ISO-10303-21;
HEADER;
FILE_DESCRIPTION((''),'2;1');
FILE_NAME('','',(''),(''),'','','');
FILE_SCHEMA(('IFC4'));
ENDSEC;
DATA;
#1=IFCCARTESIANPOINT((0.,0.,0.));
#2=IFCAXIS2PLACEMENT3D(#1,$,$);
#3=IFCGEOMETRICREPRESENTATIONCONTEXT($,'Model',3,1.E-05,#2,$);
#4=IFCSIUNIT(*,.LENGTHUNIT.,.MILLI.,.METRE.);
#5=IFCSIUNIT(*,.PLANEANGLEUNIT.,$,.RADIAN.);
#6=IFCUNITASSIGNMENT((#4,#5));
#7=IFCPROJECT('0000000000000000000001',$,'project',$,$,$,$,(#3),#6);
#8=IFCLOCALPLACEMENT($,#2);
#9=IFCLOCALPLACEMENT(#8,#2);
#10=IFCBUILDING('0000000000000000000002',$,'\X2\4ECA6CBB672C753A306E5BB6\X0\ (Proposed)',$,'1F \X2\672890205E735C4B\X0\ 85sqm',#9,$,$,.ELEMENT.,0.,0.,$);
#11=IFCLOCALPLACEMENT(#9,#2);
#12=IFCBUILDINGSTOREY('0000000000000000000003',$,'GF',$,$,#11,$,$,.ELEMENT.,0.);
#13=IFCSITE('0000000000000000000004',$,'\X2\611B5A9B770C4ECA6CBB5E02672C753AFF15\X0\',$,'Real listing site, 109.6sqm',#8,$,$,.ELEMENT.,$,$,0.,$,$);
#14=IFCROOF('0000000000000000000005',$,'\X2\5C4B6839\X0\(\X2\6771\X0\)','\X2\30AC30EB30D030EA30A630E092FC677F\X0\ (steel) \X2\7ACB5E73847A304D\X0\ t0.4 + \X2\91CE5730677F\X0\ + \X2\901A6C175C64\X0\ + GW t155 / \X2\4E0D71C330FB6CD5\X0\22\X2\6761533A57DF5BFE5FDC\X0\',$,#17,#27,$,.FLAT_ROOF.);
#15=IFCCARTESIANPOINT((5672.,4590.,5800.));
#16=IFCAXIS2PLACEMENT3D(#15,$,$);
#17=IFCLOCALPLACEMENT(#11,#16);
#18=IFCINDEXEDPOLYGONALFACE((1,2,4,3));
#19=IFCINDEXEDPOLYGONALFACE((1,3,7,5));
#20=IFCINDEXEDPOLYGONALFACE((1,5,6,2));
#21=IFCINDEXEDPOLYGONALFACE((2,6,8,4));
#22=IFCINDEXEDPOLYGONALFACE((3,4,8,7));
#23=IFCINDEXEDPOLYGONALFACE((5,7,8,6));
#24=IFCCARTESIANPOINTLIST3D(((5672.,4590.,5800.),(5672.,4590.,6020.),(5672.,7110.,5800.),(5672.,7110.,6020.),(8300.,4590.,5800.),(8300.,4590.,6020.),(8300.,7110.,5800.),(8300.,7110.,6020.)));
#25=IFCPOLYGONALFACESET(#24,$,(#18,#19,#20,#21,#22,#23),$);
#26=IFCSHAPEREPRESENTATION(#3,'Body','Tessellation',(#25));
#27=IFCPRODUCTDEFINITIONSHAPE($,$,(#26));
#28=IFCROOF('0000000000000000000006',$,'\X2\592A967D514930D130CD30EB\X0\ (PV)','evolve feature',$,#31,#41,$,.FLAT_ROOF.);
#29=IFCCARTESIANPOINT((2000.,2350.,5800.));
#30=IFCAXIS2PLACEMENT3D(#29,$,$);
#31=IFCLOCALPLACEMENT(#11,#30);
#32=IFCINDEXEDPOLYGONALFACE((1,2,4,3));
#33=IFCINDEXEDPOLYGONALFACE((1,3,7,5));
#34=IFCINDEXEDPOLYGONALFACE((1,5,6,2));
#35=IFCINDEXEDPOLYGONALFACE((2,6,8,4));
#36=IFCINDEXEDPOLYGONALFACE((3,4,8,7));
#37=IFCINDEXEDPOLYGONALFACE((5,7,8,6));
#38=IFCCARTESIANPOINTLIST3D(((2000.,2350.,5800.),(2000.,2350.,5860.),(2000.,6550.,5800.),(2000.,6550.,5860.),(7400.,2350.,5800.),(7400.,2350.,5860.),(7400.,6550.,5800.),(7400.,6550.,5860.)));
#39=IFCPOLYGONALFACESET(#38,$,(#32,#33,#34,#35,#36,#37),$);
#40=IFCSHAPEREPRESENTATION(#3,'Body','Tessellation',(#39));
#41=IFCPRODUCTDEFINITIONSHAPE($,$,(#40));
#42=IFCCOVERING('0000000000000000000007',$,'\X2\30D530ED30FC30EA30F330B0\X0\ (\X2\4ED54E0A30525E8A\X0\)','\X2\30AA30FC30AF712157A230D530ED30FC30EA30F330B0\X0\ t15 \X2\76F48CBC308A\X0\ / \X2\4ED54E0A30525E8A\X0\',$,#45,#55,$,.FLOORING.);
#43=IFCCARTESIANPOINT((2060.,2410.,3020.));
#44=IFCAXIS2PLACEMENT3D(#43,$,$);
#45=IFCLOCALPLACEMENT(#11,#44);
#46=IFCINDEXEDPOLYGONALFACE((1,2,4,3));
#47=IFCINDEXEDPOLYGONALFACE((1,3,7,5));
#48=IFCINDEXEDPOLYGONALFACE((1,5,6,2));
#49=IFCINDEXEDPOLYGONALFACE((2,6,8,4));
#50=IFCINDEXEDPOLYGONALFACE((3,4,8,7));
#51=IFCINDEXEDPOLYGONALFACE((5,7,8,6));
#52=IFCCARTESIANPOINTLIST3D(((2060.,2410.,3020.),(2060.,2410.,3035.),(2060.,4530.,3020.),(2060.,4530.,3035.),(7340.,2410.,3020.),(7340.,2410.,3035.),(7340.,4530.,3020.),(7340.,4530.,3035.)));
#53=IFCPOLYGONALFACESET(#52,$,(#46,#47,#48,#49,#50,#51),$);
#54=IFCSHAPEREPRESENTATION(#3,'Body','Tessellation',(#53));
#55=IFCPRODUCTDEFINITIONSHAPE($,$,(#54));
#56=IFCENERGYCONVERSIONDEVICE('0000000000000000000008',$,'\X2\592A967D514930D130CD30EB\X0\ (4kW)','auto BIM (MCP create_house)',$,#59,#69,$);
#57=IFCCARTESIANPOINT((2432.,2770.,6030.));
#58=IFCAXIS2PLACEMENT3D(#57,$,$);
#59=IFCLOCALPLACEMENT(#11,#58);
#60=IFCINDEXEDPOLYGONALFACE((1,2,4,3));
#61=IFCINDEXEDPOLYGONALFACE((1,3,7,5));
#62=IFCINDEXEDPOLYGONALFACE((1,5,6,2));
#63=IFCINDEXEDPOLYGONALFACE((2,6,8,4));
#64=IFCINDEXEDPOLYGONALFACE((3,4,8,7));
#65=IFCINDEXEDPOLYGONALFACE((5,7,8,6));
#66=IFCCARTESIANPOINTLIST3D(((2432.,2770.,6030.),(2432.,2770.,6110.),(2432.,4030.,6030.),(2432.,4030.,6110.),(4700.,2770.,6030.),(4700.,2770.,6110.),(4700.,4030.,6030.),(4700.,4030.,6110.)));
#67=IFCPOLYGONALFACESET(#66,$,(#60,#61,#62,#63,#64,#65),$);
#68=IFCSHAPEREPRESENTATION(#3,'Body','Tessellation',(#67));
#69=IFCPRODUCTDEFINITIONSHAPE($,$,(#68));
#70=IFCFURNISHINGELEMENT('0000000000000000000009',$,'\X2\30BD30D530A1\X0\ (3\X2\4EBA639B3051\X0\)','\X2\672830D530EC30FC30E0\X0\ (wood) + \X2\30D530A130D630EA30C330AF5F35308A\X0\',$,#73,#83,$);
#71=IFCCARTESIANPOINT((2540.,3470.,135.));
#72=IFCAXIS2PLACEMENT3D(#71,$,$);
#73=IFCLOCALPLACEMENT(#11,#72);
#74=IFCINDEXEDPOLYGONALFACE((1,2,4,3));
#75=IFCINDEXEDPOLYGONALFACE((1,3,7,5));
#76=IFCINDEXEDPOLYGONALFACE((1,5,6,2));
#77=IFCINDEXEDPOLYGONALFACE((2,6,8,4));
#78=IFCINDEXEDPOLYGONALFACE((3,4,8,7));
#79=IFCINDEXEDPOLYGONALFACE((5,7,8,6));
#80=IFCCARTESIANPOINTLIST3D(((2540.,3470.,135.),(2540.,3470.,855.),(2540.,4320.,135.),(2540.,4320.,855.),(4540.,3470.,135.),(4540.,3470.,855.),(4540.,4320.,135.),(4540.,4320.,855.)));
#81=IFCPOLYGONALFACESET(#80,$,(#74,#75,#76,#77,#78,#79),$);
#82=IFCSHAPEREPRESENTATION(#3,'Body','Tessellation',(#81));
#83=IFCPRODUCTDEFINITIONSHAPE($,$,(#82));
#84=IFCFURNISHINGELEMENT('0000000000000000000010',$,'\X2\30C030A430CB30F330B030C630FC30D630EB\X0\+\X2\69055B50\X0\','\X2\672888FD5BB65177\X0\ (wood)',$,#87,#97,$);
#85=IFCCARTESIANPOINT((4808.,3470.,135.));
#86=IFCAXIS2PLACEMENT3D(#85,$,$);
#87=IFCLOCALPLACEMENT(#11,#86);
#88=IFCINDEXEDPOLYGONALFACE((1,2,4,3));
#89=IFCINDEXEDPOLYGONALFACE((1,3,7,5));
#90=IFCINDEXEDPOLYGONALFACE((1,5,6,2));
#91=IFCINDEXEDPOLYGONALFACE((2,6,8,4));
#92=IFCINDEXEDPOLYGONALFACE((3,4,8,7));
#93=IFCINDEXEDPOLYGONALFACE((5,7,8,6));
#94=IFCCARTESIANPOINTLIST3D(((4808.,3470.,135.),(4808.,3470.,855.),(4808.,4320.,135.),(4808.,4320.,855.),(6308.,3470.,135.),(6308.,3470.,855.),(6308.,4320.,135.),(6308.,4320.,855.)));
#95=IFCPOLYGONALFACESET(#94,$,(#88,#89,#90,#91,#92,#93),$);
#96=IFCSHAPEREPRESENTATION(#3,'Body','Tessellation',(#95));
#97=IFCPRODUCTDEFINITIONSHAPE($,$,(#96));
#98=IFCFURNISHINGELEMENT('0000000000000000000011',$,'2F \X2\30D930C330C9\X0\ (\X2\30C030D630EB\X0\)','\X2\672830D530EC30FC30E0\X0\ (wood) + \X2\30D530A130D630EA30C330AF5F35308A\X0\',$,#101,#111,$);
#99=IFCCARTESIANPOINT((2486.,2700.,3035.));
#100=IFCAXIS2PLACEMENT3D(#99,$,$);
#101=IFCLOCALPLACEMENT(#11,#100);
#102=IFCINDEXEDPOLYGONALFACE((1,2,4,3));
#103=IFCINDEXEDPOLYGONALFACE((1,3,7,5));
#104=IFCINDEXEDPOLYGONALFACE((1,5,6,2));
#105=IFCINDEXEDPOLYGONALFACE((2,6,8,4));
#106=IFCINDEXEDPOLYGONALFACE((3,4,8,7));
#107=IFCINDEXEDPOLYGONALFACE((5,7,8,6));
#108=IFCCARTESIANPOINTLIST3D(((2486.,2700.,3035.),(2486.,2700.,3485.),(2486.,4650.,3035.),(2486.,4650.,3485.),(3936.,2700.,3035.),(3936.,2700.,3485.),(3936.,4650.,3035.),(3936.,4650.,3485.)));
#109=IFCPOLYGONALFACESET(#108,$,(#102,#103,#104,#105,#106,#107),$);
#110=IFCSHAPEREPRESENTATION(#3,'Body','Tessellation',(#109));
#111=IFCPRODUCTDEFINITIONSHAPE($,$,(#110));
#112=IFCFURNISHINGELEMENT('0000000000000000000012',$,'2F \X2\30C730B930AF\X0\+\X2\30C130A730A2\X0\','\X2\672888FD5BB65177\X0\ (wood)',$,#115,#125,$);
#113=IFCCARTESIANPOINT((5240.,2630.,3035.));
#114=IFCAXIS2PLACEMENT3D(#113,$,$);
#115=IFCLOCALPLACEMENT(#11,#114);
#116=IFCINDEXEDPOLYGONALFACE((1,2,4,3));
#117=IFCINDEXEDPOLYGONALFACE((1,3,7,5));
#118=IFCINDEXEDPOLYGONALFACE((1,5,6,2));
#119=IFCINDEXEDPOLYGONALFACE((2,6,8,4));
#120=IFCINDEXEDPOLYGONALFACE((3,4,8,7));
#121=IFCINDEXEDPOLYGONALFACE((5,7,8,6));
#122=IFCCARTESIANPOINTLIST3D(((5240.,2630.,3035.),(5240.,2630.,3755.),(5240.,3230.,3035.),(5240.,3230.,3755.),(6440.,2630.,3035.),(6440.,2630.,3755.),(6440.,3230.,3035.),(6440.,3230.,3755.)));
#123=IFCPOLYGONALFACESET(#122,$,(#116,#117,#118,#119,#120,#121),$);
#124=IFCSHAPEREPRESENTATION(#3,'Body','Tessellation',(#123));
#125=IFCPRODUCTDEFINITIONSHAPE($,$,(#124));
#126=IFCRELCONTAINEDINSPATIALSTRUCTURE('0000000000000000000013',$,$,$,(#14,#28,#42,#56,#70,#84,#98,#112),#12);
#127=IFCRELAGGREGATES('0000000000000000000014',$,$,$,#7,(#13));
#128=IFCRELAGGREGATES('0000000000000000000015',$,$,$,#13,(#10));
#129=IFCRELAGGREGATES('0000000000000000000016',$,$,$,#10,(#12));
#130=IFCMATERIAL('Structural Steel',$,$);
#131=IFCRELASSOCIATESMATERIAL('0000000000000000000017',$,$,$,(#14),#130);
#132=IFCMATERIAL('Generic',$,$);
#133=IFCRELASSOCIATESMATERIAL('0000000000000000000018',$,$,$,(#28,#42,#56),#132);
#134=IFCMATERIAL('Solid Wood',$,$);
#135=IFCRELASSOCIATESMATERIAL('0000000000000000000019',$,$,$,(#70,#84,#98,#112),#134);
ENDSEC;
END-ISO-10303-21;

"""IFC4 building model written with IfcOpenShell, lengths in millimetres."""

from ifc_helpers import new_model, si_unit, frame, frame_2d, origin, place, context, project, spatial, rectangle, extrude, material, element, save


model = new_model("IFC4")

# Units and contexts
model_context = context("Model", 3, precision=1e-05, world=origin())
ifc_project = project(units=[si_unit("LENGTHUNIT", "METRE", prefix="MILLI"), si_unit("PLANEANGLEUNIT", "RADIAN")], contexts=[model_context])

# Site, building, storey
site_placement = place(None, origin())
site = spatial("IfcSite", under=ifc_project, at=site_placement, Name="愛媛県今治市本町５", ObjectType="Real listing site, 109.6sqm", CompositionType="ELEMENT", RefElevation=0.0)
building_placement = place(site_placement, origin())
building = spatial("IfcBuilding", under=site, at=building_placement, Name="今治本町の家 (Proposed)", ObjectType="1F 木造平屋 85sqm", CompositionType="ELEMENT", ElevationOfRefHeight=0.0, ElevationOfTerrain=0.0)
storey_placement = place(building_placement, origin())
storey = spatial("IfcBuildingStorey", under=building, at=storey_placement, Name="GF", CompositionType="ELEMENT", Elevation=0.0)

# Shared definitions
ifc_material_1 = material(Name="Solid Wood")

# Roofs
ifc_material_2 = material(Name="Structural Steel")
roof_1_placement = place(storey_placement, frame((5672.0, 4590.0, 5800.0)))
element("IfcRoof", 1, at=roof_1_placement, inside=storey, material=ifc_material_2, Name="屋根(東)", Description="ガルバリウム鋼板 (steel) 立平葺き t0.4 + 野地板 + 通気層 + GW t155 / 不燃・法22条区域対応", PredefinedType="FLAT_ROOF", context=model_context, shape_type="SweptSolid", body=[
    extrude(rectangle(XDim=2628.0, YDim=2520.0, at=frame_2d((1314.0, 1260.0))), frame((5672.0, 4590.0, 5800.0)), (0.0, 0.0, 1.0), 220.0),
])
ifc_material_3 = material(Name="Generic")
roof_2_placement = place(storey_placement, frame((2000.0, 2350.0, 5800.0)))
element("IfcRoof", 2, at=roof_2_placement, inside=storey, material=ifc_material_3, Name="太陽光パネル (PV)", Description="evolve feature", PredefinedType="FLAT_ROOF", context=model_context, shape_type="SweptSolid", body=[
    extrude(rectangle(XDim=5400.0, YDim=4200.0, at=frame_2d((2700.0, 2100.0))), frame((2000.0, 2350.0, 5800.0)), (0.0, 0.0, 1.0), 60.0),
])

# Covering
covering_placement = place(storey_placement, frame((2060.0, 2410.0, 3020.0)))
element("IfcCovering", 3, at=covering_placement, inside=storey, material=ifc_material_3, Name="フローリング (仕上げ床)", Description="オーク無垢フローリング t15 直貼り / 仕上げ床", PredefinedType="FLOORING", context=model_context, shape_type="SweptSolid", body=[
    extrude(rectangle(XDim=5280.0, YDim=2120.0, at=frame_2d((2640.0, 1060.0))), frame((2060.0, 2410.0, 3020.0)), (0.0, 0.0, 1.0), 15.0),
])

# Energy conversion device
energy_conversion_device_placement = place(storey_placement, frame((2432.0, 2770.0, 6030.0)))
element("IfcEnergyConversionDevice", 4, at=energy_conversion_device_placement, inside=storey, material=ifc_material_3, Name="太陽光パネル (4kW)", Description="auto BIM (MCP create_house)", context=model_context, shape_type="SweptSolid", body=[
    extrude(rectangle(XDim=2268.0, YDim=1260.0, at=frame_2d((1134.0, 630.0))), frame((2432.0, 2770.0, 6030.0)), (0.0, 0.0, 1.0), 80.0),
])

# Furnishing elements
furnishing_1_placement = place(storey_placement, frame((2540.0, 3470.0, 135.0)))
element("IfcFurnishingElement", 5, at=furnishing_1_placement, inside=storey, material=ifc_material_1, Name="ソファ (3人掛け)", Description="木フレーム (wood) + ファブリック張り", context=model_context, shape_type="SweptSolid", body=[
    extrude(rectangle(XDim=2000.0, YDim=850.0, at=frame_2d((1000.0, 425.0))), frame((2540.0, 3470.0, 135.0)), (0.0, 0.0, 1.0), 720.0),
])
furnishing_2_placement = place(storey_placement, frame((4808.0, 3470.0, 135.0)))
element("IfcFurnishingElement", 6, at=furnishing_2_placement, inside=storey, material=ifc_material_1, Name="ダイニングテーブル+椅子", Description="木製家具 (wood)", context=model_context, shape_type="SweptSolid", body=[
    extrude(rectangle(XDim=1500.0, YDim=850.0, at=frame_2d((750.0, 425.0))), frame((4808.0, 3470.0, 135.0)), (0.0, 0.0, 1.0), 720.0),
])
furnishing_3_placement = place(storey_placement, frame((2486.0, 2700.0, 3035.0)))
element("IfcFurnishingElement", 7, at=furnishing_3_placement, inside=storey, material=ifc_material_1, Name="2F ベッド (ダブル)", Description="木フレーム (wood) + ファブリック張り", context=model_context, shape_type="SweptSolid", body=[
    extrude(rectangle(XDim=1450.0, YDim=1950.0, at=frame_2d((725.0, 975.0))), frame((2486.0, 2700.0, 3035.0)), (0.0, 0.0, 1.0), 450.0),
])
furnishing_4_placement = place(storey_placement, frame((5240.0, 2630.0, 3035.0)))
element("IfcFurnishingElement", 8, at=furnishing_4_placement, inside=storey, material=ifc_material_1, Name="2F デスク+チェア", Description="木製家具 (wood)", context=model_context, shape_type="SweptSolid", body=[
    extrude(rectangle(XDim=1200.0, YDim=600.0, at=frame_2d((600.0, 300.0))), frame((5240.0, 2630.0, 3035.0)), (0.0, 0.0, 1.0), 720.0),
])

save(model, "model.ifc")
